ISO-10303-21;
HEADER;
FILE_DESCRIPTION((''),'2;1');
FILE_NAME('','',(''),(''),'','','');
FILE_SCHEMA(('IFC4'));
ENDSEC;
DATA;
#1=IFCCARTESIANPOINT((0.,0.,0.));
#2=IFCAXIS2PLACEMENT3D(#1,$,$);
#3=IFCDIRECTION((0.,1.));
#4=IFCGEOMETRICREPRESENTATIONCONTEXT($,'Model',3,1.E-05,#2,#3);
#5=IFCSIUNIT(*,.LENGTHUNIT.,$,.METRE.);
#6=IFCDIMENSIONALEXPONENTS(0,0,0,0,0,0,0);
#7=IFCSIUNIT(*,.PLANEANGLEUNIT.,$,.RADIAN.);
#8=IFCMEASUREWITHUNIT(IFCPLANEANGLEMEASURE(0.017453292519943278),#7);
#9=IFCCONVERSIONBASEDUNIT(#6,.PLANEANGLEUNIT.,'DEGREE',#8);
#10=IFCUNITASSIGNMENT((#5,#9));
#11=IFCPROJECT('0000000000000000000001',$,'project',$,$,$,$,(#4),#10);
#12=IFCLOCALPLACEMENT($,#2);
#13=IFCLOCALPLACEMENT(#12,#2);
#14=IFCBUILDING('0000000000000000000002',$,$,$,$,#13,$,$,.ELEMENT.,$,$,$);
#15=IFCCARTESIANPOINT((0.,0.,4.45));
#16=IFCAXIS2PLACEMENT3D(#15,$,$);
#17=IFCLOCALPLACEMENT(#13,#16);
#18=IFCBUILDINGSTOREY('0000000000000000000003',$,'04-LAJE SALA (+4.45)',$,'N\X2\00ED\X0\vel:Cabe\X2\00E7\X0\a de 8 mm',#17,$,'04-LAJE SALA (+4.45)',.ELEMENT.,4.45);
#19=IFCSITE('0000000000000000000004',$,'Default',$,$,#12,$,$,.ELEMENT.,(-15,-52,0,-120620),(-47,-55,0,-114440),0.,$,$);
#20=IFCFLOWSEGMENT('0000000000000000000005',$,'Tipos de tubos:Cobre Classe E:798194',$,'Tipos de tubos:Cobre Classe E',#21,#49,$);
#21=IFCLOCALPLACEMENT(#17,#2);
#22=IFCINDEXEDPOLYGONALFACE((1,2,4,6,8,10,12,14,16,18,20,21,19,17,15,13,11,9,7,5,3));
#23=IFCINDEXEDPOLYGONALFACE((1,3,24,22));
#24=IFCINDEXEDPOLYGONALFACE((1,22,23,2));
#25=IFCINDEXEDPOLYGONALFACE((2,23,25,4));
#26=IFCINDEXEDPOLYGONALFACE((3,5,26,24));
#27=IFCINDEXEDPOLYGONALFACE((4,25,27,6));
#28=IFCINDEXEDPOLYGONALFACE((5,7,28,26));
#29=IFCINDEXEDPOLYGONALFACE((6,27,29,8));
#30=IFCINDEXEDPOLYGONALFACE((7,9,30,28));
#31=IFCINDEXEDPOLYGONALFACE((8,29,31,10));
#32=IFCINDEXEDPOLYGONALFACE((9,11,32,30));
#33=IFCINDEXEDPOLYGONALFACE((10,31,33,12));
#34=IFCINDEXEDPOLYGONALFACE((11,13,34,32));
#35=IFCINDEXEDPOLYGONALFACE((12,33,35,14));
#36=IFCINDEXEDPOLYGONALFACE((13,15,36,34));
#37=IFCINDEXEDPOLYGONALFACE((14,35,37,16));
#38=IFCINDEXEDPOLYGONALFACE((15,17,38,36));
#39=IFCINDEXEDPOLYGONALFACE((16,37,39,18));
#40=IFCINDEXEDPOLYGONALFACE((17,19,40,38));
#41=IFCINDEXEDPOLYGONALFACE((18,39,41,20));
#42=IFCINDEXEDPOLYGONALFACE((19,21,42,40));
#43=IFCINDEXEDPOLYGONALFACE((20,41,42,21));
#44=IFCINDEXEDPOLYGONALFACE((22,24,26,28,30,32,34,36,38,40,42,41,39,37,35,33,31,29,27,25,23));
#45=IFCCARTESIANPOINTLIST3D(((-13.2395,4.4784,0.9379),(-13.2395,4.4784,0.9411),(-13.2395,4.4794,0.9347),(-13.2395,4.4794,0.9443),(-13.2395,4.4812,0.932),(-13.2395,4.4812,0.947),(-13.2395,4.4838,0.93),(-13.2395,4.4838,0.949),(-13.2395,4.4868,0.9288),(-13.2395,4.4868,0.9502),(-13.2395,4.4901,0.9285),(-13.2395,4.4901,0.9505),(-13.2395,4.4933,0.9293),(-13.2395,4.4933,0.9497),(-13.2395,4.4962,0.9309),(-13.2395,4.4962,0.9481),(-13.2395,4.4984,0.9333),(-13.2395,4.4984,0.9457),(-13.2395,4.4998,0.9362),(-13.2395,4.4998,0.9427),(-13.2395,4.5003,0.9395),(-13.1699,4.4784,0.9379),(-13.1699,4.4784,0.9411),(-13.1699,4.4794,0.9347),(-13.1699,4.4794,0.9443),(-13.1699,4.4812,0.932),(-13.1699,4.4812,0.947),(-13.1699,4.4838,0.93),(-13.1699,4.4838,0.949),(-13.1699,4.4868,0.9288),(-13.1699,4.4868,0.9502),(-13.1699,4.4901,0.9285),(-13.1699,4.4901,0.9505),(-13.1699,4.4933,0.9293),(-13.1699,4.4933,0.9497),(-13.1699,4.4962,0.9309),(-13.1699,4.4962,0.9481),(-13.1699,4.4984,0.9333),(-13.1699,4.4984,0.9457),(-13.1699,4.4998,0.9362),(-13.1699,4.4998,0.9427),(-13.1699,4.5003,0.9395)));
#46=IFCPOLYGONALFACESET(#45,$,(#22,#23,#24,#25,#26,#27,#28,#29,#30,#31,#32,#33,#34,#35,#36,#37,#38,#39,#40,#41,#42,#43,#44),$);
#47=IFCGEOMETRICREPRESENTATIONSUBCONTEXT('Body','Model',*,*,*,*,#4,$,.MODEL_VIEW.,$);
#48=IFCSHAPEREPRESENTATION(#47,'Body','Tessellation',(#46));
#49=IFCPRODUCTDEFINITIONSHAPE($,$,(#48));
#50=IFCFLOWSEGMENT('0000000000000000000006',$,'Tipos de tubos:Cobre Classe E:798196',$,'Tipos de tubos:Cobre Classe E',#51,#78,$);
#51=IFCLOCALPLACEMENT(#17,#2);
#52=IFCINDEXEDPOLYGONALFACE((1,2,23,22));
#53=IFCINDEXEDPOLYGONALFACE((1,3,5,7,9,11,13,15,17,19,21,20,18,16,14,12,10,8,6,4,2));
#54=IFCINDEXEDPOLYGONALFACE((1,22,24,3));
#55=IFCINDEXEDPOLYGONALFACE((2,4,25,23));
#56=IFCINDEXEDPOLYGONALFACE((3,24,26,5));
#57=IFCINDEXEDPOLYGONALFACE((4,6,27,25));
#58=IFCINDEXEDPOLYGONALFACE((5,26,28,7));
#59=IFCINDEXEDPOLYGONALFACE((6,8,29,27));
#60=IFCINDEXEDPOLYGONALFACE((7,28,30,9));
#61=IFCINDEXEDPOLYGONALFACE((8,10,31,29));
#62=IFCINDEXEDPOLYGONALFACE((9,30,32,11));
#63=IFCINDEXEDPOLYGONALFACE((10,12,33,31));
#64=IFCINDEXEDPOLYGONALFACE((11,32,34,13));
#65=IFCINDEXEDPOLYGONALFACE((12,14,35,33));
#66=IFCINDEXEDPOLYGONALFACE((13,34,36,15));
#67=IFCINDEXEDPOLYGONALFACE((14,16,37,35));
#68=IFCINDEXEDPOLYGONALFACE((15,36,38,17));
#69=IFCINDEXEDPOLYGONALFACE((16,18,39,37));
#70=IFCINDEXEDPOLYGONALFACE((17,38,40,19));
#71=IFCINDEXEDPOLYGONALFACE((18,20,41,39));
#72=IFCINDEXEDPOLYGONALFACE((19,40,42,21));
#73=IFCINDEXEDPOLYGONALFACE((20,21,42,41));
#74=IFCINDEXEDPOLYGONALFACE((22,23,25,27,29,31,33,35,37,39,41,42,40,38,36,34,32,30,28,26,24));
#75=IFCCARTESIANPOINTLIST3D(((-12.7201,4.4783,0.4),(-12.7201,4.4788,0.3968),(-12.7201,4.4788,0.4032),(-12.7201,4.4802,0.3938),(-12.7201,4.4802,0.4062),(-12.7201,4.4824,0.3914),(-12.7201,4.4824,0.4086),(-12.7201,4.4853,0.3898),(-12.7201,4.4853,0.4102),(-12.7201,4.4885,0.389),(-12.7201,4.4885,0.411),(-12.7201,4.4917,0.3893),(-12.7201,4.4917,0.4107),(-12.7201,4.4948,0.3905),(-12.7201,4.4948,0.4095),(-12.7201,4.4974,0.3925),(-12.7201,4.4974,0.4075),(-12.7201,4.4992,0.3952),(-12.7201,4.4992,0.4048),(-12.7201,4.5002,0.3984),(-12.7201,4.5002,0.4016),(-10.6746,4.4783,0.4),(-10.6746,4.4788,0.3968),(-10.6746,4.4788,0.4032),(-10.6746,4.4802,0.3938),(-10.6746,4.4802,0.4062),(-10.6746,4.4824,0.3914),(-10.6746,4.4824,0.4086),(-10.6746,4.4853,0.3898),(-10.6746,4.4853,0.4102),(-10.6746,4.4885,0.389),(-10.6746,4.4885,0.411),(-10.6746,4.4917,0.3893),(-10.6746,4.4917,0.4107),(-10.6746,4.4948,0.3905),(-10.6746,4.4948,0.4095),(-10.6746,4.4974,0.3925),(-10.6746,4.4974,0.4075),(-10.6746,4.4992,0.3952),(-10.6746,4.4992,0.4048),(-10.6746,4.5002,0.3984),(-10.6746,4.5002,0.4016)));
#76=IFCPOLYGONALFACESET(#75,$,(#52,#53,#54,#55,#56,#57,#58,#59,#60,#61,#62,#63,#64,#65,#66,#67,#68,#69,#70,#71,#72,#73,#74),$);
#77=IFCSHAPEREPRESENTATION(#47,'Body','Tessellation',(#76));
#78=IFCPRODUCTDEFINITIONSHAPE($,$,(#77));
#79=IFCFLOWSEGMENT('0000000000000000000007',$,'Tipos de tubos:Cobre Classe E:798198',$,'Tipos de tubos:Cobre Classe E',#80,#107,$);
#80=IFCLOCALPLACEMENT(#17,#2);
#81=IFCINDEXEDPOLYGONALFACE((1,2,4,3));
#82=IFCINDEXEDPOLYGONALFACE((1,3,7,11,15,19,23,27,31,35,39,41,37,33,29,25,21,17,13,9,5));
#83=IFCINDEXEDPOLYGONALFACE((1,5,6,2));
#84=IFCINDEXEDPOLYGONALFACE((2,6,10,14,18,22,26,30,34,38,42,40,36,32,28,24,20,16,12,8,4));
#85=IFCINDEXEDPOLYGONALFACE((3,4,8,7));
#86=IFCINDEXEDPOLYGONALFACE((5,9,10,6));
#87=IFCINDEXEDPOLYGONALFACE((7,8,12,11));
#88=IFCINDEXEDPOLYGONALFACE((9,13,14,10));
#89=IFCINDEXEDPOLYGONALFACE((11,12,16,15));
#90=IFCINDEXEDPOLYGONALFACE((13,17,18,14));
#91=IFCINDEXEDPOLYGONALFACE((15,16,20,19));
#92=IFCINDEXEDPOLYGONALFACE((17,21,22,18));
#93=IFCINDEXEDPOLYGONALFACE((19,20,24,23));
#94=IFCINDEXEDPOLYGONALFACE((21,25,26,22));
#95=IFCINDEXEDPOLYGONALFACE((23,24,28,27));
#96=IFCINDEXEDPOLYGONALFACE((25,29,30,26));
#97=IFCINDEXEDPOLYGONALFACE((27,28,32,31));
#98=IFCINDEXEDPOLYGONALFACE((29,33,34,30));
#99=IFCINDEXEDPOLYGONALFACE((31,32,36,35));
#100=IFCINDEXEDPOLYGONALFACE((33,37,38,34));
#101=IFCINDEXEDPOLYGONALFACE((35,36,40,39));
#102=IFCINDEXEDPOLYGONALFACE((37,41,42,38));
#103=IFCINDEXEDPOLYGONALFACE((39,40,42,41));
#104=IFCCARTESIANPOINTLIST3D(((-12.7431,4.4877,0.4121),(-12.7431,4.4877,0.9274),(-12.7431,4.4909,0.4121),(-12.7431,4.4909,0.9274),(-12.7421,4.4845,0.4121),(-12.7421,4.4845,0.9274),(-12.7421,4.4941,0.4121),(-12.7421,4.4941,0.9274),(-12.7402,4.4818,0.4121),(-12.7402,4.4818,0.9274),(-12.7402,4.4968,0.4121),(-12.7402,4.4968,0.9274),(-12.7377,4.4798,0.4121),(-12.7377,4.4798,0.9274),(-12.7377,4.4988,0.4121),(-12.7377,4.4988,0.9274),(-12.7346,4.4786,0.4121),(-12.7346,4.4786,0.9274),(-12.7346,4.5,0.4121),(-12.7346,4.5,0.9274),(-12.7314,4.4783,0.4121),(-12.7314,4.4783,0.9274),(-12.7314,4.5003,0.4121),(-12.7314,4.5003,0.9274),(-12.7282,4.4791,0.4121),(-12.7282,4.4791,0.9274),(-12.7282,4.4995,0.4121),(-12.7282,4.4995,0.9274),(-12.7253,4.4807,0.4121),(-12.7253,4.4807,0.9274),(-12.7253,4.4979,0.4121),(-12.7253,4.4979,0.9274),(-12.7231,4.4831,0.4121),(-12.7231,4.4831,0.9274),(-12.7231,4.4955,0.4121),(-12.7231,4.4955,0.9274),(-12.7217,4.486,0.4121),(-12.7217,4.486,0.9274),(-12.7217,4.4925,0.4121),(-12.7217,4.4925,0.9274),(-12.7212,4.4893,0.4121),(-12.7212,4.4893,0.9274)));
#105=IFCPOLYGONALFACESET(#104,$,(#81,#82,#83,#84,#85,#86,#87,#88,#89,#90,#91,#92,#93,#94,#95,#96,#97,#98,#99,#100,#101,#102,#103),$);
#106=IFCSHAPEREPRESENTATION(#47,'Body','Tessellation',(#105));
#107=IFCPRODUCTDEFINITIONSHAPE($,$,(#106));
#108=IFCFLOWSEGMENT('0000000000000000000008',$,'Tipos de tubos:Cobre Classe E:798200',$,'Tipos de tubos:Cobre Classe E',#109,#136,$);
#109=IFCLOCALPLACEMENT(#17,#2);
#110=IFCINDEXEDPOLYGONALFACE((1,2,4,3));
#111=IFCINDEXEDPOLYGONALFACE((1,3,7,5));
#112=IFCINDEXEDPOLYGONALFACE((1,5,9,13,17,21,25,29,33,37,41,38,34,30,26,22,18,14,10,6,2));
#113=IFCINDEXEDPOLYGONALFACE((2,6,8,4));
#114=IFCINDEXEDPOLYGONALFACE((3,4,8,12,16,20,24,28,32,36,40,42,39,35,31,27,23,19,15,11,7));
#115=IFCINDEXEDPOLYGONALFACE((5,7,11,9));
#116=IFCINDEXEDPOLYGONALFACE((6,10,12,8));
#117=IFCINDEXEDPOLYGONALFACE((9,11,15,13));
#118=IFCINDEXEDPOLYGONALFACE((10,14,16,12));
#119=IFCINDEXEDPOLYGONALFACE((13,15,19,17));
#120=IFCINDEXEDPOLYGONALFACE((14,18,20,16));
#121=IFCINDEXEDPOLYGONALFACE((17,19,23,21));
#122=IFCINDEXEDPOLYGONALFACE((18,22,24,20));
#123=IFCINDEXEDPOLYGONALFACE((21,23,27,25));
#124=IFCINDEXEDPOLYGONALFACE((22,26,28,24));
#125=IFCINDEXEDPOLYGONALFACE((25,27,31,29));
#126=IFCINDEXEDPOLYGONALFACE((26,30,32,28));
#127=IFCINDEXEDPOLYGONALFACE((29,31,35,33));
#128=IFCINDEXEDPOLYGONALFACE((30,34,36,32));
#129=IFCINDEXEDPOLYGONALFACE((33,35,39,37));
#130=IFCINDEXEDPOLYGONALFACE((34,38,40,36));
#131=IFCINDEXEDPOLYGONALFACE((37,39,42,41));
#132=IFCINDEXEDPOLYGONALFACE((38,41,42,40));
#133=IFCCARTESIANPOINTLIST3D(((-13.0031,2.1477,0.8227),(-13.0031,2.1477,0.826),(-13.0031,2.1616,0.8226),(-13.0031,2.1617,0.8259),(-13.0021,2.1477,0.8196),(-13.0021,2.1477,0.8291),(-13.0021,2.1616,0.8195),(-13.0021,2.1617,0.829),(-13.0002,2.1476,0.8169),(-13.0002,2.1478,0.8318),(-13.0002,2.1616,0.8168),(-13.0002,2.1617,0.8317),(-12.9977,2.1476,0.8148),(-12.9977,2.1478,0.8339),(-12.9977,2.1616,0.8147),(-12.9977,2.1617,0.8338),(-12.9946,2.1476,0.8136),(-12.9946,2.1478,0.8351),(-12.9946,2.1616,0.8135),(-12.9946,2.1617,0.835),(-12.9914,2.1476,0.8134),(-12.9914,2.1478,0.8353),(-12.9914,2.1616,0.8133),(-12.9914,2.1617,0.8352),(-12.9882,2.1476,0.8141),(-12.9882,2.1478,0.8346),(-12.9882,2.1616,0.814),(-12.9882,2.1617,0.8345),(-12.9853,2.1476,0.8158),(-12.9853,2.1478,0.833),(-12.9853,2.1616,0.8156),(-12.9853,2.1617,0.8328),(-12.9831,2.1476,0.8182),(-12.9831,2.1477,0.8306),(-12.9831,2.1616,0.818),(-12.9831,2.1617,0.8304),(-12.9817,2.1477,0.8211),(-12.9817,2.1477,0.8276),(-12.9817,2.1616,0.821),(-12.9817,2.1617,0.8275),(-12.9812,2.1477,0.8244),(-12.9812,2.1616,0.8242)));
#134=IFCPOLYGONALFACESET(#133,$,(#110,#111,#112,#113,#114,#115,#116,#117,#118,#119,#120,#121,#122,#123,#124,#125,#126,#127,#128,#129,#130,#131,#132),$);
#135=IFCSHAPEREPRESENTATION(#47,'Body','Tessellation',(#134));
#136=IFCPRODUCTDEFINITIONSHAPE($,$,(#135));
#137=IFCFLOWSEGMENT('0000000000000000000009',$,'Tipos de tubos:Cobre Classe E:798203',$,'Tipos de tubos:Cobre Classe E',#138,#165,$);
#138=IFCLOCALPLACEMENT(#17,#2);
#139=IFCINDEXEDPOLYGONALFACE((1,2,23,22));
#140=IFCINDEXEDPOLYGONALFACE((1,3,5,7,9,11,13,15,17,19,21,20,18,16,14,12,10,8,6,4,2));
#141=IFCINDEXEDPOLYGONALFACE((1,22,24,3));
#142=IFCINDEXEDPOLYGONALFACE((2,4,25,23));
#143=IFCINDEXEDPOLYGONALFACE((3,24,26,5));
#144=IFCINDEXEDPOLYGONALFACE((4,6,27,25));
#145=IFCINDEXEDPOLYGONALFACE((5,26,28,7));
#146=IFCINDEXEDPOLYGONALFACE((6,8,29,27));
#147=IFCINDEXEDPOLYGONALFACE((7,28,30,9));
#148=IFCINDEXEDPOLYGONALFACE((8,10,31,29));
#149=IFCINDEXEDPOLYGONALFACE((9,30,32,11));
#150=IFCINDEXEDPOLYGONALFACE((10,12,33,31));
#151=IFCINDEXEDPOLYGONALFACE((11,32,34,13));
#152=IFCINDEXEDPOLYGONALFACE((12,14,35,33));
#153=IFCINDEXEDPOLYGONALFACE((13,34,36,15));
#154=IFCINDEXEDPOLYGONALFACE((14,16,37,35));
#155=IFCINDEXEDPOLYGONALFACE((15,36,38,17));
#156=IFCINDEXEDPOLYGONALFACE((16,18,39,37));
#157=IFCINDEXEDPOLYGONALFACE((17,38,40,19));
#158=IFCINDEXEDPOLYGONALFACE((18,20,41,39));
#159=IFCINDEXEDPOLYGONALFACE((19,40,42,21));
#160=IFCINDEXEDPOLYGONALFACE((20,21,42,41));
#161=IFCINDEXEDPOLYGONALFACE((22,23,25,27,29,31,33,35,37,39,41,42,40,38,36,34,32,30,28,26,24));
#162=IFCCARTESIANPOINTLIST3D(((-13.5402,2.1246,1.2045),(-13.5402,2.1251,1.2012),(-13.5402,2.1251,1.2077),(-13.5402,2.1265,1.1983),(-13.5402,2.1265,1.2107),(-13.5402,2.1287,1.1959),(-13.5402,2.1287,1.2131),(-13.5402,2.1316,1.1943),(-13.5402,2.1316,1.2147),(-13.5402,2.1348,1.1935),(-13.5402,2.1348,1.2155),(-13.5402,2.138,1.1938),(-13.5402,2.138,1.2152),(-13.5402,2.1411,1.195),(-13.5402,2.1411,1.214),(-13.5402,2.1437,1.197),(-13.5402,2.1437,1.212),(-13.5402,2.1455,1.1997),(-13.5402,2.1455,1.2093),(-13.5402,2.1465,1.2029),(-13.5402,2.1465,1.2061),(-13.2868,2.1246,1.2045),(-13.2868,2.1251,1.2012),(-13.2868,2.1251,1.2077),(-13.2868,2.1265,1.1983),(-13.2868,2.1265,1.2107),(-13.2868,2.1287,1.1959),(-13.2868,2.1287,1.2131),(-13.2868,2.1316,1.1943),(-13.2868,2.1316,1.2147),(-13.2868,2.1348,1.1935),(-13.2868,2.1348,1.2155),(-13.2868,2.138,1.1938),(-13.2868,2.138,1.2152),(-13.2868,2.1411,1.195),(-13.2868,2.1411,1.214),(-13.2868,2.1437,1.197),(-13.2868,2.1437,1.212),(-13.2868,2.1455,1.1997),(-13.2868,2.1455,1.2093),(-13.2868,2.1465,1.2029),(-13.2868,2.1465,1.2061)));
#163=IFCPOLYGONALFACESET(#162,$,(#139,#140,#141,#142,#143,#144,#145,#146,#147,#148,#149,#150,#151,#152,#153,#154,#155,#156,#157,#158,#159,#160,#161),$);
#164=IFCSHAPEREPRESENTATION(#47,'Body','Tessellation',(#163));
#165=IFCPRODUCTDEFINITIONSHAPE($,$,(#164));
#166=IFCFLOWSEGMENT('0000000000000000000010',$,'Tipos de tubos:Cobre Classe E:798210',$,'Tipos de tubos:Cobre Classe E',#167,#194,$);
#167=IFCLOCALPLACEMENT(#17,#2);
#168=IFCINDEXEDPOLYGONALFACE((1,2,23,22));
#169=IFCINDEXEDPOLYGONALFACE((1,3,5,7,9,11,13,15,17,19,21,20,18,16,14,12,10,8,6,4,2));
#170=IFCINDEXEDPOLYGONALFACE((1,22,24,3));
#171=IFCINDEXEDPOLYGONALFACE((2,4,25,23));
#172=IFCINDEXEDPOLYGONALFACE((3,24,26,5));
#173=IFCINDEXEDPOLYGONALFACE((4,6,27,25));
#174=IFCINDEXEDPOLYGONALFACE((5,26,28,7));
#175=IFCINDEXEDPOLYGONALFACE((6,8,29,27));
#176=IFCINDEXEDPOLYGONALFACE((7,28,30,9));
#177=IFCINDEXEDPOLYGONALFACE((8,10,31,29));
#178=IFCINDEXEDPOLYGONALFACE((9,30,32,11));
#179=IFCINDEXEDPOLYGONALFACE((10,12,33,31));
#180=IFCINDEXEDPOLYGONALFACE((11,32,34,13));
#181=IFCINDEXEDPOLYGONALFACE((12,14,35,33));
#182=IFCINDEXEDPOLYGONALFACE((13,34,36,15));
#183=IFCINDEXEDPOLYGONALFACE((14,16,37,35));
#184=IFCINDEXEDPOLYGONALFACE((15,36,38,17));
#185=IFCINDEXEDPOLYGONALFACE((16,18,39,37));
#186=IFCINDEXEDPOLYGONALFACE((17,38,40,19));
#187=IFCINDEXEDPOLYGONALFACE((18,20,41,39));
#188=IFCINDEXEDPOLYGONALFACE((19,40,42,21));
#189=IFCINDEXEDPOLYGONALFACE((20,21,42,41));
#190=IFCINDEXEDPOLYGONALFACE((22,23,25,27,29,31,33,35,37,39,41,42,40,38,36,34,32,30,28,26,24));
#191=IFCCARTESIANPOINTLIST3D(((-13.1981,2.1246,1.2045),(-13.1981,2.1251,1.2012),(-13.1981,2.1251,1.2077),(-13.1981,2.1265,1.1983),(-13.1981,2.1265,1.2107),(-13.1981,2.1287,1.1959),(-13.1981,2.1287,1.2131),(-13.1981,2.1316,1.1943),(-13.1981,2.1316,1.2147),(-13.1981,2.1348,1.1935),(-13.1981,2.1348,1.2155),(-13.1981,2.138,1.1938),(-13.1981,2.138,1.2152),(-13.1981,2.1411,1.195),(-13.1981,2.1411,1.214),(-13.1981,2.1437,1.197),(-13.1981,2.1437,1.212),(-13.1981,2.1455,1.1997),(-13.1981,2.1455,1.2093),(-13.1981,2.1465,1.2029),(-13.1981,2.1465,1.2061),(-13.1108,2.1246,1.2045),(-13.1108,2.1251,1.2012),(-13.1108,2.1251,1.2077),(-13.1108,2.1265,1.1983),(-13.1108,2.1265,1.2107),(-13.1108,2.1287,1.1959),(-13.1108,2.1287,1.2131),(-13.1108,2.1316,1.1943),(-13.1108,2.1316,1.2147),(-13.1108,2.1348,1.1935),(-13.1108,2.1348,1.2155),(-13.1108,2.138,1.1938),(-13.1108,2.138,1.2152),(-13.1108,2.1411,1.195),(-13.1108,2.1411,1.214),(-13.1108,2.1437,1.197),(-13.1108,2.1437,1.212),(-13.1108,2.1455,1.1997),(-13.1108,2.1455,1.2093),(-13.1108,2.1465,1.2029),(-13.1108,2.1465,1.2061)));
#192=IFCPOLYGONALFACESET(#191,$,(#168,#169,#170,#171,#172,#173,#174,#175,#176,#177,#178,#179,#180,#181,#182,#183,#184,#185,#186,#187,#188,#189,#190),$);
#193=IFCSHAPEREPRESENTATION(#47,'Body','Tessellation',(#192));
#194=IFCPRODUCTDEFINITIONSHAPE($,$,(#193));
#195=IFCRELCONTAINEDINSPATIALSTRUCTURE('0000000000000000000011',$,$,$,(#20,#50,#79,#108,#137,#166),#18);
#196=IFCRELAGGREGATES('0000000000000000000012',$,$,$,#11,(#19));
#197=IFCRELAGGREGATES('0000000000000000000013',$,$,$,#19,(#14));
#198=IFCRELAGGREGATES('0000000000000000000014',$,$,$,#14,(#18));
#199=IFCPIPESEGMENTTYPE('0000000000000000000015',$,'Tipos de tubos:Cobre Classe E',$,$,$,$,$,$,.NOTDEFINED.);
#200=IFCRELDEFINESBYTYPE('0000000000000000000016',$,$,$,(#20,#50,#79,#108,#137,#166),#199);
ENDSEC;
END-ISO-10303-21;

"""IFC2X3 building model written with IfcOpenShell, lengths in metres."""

from ifc_helpers import new_model, entity, si_unit, converted_unit, direction, frame, frame_2d, origin, origin_2d_with_axis, place, context, subcontext, project, spatial, circle, extrude, type_object, element, save


model = new_model("IFC2X3")

# Units and contexts
model_context = context("Model", 3, precision=1e-05, world=origin(), true_north=direction((0.0, 1.0)))
body_context = subcontext(model_context, "Body", "Model", "MODEL_VIEW")
ifc_project = project(units=[si_unit("LENGTHUNIT", "METRE"), converted_unit("PLANEANGLEUNIT", "DEGREE", entity("IfcPlaneAngleMeasure", 0.017453292519943278), si_unit("PLANEANGLEUNIT", "RADIAN"), dimensions=[0, 0, 0, 0, 0, 0, 0])], contexts=[model_context])

# Site, building, storey
site_placement = place(None, origin())
site = spatial("IfcSite", under=ifc_project, at=site_placement, Name="Default", CompositionType="ELEMENT", RefLatitude=(-15, -52, 0, -120620), RefLongitude=(-47, -55, 0, -114440), RefElevation=0.0)
building_placement = place(site_placement, origin())
building = spatial("IfcBuilding", under=site, at=building_placement, CompositionType="ELEMENT")
storey_placement = place(building_placement, frame((0.0, 0.0, 4.45)))
storey = spatial("IfcBuildingStorey", under=building, at=storey_placement, Name="04-LAJE SALA (+4.45)", ObjectType="Nível:Cabeça de 8 mm", LongName="04-LAJE SALA (+4.45)", CompositionType="ELEMENT", Elevation=4.45)

# Flow segments
pipe_segment_type_1 = type_object("IfcPipeSegmentType", Name="Tipos de tubos:Cobre Classe E", PredefinedType="NOTDEFINED")
flow_segment_1_placement = place(storey_placement, origin())
element("IfcFlowSegment", 1, at=flow_segment_1_placement, inside=storey, type_object=pipe_segment_type_1, Name="Tipos de tubos:Cobre Classe E:798194", ObjectType="Tipos de tubos:Cobre Classe E", context=body_context, shape_type="SweptSolid", body=[
    extrude(circle(Radius=0.011, at=origin_2d_with_axis()), frame((-13.2395, 4.4893, 0.9395), z_axis=(1.0, 0.0, 0.0), x_axis=(0.0, 1.0, 0.0)), (0.0, 0.0, 1.0), 0.0696),
])
flow_segment_2_placement = place(storey_placement, origin())
element("IfcFlowSegment", 2, at=flow_segment_2_placement, inside=storey, type_object=pipe_segment_type_1, Name="Tipos de tubos:Cobre Classe E:798196", ObjectType="Tipos de tubos:Cobre Classe E", context=body_context, shape_type="SweptSolid", body=[
    extrude(circle(Radius=0.011, at=origin_2d_with_axis()), frame((-12.7201, 4.4893, 0.4), z_axis=(1.0, 0.0, 0.0), x_axis=(0.0, -1.0, 0.0)), (0.0, 0.0, 1.0), 2.0455),
])
flow_segment_3_placement = place(storey_placement, origin())
element("IfcFlowSegment", 3, at=flow_segment_3_placement, inside=storey, type_object=pipe_segment_type_1, Name="Tipos de tubos:Cobre Classe E:798198", ObjectType="Tipos de tubos:Cobre Classe E", context=body_context, shape_type="SweptSolid", body=[
    extrude(circle(Radius=0.011, at=frame_2d((0.0, 0.0), x_axis=(1.0, 0.0))), frame((-12.7322, 4.4893, 0.4121)), (0.0, 0.0, 1.0), 0.5153),
])
flow_segment_4_placement = place(storey_placement, origin())
element("IfcFlowSegment", 4, at=flow_segment_4_placement, inside=storey, type_object=pipe_segment_type_1, Name="Tipos de tubos:Cobre Classe E:798200", ObjectType="Tipos de tubos:Cobre Classe E", context=body_context, shape_type="SweptSolid", body=[
    extrude(circle(Radius=0.011, at=frame_2d((0.0, 0.0), x_axis=(1.0, 0.0))), frame((-12.9922, 2.1616, 0.8242), z_axis=(0.0, -0.999966, 0.008225), x_axis=(1.0, 0.0, 0.0)), (0.0, 0.0, 1.0), 0.0139),
])
flow_segment_5_placement = place(storey_placement, origin())
element("IfcFlowSegment", 5, at=flow_segment_5_placement, inside=storey, type_object=pipe_segment_type_1, Name="Tipos de tubos:Cobre Classe E:798203", ObjectType="Tipos de tubos:Cobre Classe E", context=body_context, shape_type="SweptSolid", body=[
    extrude(circle(Radius=0.011, at=origin_2d_with_axis()), frame((-13.5402, 2.1356, 1.2045), z_axis=(1.0, 0.0, 0.0), x_axis=(0.0, -1.0, 0.0)), (0.0, 0.0, 1.0), 0.2534),
])
flow_segment_6_placement = place(storey_placement, origin())
element("IfcFlowSegment", 6, at=flow_segment_6_placement, inside=storey, type_object=pipe_segment_type_1, Name="Tipos de tubos:Cobre Classe E:798210", ObjectType="Tipos de tubos:Cobre Classe E", context=body_context, shape_type="SweptSolid", body=[
    extrude(circle(Radius=0.011, at=origin_2d_with_axis()), frame((-13.1981, 2.1356, 1.2045), z_axis=(1.0, 0.0, 0.0), x_axis=(0.0, -1.0, 0.0)), (0.0, 0.0, 1.0), 0.0874),
])

save(model, "model.ifc")
